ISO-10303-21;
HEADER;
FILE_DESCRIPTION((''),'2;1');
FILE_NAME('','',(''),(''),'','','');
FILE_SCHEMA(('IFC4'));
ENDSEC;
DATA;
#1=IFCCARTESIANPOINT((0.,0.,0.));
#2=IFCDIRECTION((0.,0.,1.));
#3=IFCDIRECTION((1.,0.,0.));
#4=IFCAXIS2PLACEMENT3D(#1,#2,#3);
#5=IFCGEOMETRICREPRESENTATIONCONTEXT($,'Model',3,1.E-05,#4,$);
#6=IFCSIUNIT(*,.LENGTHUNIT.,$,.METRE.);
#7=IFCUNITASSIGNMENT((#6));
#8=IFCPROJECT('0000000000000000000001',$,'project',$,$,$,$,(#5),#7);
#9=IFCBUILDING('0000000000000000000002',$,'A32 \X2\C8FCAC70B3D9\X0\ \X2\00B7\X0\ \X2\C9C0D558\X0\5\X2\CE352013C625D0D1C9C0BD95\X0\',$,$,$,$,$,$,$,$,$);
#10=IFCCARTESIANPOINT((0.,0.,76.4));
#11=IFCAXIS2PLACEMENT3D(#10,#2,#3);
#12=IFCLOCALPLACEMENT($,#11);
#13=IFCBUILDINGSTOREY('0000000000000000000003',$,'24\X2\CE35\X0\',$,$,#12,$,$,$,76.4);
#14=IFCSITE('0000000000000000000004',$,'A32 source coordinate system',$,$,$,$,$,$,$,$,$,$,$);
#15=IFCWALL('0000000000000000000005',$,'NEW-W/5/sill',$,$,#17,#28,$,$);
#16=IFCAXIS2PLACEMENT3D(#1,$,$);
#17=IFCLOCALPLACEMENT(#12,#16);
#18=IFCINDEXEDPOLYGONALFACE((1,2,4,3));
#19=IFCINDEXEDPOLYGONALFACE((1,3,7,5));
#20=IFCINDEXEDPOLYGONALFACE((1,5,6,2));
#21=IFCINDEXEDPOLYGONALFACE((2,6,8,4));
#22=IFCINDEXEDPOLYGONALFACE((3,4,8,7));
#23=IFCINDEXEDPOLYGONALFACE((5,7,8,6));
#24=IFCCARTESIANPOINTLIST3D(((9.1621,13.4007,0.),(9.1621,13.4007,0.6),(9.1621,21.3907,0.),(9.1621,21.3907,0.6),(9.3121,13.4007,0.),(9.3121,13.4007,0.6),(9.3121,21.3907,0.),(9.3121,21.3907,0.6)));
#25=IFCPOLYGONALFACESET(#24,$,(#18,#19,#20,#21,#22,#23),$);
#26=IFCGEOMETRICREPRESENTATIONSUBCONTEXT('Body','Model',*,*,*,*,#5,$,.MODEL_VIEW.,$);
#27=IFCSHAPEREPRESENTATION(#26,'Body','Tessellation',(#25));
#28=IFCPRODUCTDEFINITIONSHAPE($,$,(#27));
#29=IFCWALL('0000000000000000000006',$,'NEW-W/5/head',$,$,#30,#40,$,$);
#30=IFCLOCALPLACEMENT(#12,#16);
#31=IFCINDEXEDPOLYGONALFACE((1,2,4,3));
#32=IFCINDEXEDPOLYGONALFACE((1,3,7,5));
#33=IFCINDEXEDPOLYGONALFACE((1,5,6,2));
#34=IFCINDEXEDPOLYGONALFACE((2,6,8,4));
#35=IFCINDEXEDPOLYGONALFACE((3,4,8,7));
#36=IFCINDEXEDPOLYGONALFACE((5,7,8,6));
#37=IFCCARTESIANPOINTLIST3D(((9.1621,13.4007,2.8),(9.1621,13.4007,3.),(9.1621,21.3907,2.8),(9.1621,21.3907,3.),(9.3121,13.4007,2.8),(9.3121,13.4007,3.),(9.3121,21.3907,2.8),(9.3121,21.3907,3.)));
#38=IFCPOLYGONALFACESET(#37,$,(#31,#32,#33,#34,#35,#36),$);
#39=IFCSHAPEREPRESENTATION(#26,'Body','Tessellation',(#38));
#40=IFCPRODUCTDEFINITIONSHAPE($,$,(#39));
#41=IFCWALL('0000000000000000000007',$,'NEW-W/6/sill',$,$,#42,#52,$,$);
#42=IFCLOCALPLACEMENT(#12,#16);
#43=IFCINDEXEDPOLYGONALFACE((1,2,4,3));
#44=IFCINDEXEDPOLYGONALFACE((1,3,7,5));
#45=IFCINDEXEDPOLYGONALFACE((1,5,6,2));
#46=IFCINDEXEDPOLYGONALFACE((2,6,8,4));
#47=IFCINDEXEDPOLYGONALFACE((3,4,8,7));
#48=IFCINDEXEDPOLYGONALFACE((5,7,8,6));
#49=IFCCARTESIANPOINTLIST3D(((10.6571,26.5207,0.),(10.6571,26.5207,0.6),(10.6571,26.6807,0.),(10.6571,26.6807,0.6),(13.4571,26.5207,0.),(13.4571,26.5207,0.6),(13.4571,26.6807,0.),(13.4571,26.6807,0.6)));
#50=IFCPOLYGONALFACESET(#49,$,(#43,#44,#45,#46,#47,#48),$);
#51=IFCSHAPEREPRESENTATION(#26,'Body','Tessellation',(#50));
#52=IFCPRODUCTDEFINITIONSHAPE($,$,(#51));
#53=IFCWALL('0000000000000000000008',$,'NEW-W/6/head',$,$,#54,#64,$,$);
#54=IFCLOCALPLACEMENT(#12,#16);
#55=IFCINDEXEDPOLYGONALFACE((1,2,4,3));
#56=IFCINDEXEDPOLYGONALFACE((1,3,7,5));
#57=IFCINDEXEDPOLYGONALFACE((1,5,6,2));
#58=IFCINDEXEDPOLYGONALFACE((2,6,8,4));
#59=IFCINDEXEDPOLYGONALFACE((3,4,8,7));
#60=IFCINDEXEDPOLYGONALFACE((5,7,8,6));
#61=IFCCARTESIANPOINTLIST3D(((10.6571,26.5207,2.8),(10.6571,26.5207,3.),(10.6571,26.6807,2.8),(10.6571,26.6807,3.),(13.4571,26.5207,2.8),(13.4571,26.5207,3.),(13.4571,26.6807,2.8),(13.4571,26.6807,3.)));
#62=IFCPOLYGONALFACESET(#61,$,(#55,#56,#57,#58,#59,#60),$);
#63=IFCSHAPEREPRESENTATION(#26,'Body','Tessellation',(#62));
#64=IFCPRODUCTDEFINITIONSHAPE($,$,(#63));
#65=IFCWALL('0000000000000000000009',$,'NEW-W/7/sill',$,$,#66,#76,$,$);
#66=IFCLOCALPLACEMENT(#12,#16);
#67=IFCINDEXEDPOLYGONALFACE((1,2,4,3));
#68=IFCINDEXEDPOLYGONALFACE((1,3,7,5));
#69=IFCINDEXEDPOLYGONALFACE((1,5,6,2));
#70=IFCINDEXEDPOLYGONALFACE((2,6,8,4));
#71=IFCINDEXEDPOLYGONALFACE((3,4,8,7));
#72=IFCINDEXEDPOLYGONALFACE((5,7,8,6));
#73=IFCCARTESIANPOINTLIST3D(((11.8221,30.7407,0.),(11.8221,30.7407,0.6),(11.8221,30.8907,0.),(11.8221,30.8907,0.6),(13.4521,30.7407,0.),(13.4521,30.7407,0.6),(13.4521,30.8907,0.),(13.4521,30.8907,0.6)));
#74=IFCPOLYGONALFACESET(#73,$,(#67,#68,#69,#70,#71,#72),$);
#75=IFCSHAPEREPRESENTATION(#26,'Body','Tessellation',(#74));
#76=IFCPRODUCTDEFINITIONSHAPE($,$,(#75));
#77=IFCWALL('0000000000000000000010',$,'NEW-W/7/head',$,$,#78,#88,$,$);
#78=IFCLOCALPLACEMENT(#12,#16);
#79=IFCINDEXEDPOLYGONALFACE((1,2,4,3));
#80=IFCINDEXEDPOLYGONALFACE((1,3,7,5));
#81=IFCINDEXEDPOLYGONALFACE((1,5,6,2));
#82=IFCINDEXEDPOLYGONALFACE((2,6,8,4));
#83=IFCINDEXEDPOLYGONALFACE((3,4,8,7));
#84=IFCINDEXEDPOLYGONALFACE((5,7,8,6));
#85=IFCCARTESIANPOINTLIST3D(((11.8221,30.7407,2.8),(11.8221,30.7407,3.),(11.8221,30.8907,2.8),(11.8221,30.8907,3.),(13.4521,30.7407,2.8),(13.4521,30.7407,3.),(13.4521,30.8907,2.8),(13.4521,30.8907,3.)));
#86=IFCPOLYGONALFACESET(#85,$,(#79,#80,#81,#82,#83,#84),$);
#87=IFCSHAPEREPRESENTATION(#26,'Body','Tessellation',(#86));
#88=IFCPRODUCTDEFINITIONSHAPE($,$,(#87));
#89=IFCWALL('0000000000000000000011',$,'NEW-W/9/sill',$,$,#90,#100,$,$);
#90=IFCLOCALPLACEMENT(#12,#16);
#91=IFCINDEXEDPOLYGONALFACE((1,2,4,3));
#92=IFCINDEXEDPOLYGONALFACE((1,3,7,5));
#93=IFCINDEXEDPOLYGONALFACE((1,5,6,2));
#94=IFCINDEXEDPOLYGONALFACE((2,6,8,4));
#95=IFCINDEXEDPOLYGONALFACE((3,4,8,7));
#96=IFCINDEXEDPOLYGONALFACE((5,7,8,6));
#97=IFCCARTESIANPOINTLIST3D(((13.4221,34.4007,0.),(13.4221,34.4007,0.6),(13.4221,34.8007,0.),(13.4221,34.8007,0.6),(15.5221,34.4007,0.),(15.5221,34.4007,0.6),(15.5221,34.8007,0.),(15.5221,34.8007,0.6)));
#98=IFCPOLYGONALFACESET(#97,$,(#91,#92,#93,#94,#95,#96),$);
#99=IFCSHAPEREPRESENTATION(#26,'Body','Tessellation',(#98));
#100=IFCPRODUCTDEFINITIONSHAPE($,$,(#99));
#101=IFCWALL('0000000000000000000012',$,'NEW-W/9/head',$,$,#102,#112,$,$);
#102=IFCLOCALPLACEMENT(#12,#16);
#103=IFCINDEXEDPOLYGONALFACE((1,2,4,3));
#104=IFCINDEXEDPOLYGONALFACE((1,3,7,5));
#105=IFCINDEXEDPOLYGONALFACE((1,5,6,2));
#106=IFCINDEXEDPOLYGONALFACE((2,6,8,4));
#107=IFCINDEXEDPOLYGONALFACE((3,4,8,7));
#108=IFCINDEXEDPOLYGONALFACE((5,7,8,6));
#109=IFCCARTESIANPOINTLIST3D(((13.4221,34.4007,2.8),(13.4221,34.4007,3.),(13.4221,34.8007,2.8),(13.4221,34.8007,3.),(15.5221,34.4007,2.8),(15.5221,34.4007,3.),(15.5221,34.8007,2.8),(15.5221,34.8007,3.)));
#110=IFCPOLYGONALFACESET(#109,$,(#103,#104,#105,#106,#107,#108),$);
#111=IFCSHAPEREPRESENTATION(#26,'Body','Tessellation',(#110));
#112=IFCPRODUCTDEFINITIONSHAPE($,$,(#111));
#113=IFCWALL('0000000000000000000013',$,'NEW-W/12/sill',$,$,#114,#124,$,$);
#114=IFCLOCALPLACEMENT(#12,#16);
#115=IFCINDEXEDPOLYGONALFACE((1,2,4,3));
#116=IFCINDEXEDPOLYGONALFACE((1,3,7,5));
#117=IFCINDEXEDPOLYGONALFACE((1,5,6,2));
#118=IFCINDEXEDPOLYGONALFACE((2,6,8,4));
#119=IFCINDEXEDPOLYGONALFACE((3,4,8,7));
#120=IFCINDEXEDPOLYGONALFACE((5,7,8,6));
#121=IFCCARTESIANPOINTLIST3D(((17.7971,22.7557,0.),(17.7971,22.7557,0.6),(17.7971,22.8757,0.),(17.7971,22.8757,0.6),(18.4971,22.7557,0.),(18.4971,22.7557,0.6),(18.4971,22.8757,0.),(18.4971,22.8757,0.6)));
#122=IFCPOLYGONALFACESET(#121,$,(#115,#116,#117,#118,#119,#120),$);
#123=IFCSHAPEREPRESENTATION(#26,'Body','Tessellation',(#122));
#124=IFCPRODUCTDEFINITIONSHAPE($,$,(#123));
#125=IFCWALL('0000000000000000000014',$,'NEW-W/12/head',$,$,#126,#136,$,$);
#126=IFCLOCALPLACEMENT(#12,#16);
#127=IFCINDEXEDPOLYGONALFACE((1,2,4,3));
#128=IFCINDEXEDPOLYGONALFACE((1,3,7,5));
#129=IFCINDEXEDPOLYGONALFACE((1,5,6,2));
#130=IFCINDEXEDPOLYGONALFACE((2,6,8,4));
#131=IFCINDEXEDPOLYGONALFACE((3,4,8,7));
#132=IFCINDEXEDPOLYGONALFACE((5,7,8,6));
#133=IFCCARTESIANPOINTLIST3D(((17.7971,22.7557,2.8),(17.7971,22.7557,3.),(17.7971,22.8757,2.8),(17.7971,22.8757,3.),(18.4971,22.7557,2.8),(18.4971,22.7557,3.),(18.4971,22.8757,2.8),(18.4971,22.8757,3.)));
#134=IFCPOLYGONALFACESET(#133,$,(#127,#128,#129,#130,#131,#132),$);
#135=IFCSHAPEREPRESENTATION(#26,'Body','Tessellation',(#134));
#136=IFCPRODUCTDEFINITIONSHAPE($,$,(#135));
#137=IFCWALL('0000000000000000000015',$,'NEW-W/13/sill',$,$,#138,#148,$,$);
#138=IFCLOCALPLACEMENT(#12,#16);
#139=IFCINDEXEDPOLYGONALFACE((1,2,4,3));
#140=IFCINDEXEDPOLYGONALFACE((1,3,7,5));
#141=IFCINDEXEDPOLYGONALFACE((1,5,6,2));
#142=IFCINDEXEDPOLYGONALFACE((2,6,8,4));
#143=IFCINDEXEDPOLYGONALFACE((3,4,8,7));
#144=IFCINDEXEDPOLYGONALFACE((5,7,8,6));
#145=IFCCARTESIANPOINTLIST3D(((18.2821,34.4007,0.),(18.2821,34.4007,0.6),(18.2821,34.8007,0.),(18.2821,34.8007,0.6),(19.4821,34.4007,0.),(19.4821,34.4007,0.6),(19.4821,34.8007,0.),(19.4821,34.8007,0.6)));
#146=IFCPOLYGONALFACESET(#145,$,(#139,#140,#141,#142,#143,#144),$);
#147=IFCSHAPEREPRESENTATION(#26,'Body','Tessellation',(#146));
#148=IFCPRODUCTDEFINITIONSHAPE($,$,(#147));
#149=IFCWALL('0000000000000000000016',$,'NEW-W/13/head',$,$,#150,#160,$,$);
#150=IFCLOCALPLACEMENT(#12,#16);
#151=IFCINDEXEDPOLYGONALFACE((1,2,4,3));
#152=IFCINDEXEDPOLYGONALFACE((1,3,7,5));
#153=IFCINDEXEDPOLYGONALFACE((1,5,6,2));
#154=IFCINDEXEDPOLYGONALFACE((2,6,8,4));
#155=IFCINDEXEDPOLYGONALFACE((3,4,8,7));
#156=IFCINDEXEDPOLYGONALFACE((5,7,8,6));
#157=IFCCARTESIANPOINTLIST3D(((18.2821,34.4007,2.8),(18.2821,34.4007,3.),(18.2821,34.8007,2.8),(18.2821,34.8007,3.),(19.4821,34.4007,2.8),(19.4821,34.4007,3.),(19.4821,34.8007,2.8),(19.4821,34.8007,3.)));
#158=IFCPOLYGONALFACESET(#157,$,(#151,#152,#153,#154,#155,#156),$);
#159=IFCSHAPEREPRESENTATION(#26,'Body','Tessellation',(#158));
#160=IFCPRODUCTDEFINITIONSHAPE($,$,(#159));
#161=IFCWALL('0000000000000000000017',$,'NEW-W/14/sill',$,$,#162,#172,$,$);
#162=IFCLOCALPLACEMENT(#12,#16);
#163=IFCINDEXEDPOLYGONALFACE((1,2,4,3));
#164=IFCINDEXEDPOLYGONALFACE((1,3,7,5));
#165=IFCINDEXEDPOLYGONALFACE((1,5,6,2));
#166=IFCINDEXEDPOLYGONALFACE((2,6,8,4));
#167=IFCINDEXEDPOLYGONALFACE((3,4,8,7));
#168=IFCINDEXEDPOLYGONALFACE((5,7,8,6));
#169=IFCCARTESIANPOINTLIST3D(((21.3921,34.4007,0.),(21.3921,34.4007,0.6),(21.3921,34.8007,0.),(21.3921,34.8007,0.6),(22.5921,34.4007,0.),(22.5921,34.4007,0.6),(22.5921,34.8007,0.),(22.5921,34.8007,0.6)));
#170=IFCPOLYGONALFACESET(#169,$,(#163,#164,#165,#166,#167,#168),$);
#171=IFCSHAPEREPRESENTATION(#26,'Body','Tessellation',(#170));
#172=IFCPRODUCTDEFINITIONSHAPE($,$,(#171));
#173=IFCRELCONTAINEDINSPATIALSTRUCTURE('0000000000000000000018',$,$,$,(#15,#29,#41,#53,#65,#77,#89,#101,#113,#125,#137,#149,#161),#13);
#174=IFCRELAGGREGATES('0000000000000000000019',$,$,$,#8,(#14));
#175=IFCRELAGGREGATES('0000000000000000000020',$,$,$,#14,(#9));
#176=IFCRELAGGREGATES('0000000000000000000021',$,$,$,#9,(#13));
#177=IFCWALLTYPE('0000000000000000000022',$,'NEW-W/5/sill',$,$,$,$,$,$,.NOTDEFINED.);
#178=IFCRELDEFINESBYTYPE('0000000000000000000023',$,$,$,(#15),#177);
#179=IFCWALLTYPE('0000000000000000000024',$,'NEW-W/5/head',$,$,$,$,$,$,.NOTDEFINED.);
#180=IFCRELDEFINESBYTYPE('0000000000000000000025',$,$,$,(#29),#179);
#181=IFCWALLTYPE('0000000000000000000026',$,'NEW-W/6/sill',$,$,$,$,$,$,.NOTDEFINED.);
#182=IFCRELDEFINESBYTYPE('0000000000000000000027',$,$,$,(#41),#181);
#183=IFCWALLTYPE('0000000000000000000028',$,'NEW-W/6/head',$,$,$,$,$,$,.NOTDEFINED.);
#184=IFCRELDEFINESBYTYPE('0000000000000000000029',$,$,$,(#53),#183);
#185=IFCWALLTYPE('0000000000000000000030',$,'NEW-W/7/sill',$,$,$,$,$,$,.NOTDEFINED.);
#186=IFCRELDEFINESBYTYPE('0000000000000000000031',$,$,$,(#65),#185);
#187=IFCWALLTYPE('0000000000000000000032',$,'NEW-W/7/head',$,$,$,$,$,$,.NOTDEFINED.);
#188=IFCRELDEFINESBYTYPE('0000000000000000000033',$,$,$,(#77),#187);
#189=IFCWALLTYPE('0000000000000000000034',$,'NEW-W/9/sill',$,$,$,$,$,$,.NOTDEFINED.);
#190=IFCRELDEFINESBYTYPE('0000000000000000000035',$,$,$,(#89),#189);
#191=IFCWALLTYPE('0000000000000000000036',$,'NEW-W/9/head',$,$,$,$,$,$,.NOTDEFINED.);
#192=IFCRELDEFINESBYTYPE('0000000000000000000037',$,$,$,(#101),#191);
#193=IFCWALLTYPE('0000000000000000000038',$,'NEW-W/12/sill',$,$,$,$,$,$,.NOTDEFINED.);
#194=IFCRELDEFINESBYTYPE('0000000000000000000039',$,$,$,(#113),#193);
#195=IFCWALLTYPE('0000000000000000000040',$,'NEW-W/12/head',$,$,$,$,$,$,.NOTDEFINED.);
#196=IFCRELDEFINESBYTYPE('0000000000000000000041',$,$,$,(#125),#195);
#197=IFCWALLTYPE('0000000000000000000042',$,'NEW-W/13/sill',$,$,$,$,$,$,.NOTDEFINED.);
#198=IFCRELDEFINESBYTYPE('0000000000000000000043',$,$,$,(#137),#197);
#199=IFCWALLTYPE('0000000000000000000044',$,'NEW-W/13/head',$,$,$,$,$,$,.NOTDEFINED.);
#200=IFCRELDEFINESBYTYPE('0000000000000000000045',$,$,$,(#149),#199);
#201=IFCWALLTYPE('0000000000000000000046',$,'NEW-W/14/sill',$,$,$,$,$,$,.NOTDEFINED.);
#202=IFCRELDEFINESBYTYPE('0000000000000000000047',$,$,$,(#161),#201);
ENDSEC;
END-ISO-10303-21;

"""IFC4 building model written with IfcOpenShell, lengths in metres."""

from ifc_helpers import new_model, si_unit, frame, origin, origin_with_axes, place, context, subcontext, project, spatial, polyline, outline, extrude, source, transform, mapped, type_object, type_shapes, element, save


model = new_model("IFC4")

# Units and contexts
model_context = context("Model", 3, precision=1e-05, world=origin_with_axes())
body_context = subcontext(model_context, "Body", "Model", "MODEL_VIEW")
ifc_project = project(units=[si_unit("LENGTHUNIT", "METRE")], contexts=[model_context])

# Site, building, storey
site = spatial("IfcSite", under=ifc_project, Name="A32 source coordinate system")
building = spatial("IfcBuilding", under=site, Name="A32 주거동 · 지하5층–옥탑지붕")
storey_placement = place(None, frame((0.0, 0.0, 76.4), z_axis=(0.0, 0.0, 1.0), x_axis=(1.0, 0.0, 0.0)))
storey = spatial("IfcBuildingStorey", under=building, at=storey_placement, Name="24층", Elevation=76.4)

# Walls
wall_type_1 = type_object("IfcWallType", Name="NEW-W/5/sill", PredefinedType="NOTDEFINED")
shared_shape_1 = source(origin(), body_context, "Body", "SweptSolid", [
    extrude(outline(polyline([(9.1621, 13.4007), (9.1621, 21.3907), (9.3121, 21.3907), (9.3121, 13.4007), (9.1621, 13.4007)])), origin(), (0.0, 0.0, 1.0), 0.6),
])
type_shapes(wall_type_1, [shared_shape_1])
wall_1_placement = place(storey_placement, origin_with_axes())
element("IfcWall", 1, at=wall_1_placement, inside=storey, type_object=wall_type_1, Name="NEW-W/5/sill", context=body_context, shape_type="MappedRepresentation", body=[
    mapped(shared_shape_1, transform((0.0, 0.0, 0.0), scale=1.0)),
])
wall_type_2 = type_object("IfcWallType", Name="NEW-W/5/head", PredefinedType="NOTDEFINED")
shared_shape_2 = source(origin(), body_context, "Body", "SweptSolid", [
    extrude(outline(polyline([(9.1621, 13.4007), (9.1621, 21.3907), (9.3121, 21.3907), (9.3121, 13.4007), (9.1621, 13.4007)])), frame((0.0, 0.0, 2.8)), (0.0, 0.0, 1.0), 0.2),
])
type_shapes(wall_type_2, [shared_shape_2])
wall_2_placement = place(storey_placement, origin_with_axes())
element("IfcWall", 2, at=wall_2_placement, inside=storey, type_object=wall_type_2, Name="NEW-W/5/head", context=body_context, shape_type="MappedRepresentation", body=[
    mapped(shared_shape_2, transform((0.0, 0.0, 0.0), scale=1.0)),
])
wall_type_3 = type_object("IfcWallType", Name="NEW-W/6/sill", PredefinedType="NOTDEFINED")
shared_shape_3 = source(origin(), body_context, "Body", "SweptSolid", [
    extrude(outline(polyline([(10.6571, 26.5207), (10.6571, 26.6807), (13.4571, 26.6807), (13.4571, 26.5207), (10.6571, 26.5207)])), origin(), (0.0, 0.0, 1.0), 0.6),
])
type_shapes(wall_type_3, [shared_shape_3])
wall_3_placement = place(storey_placement, origin_with_axes())
element("IfcWall", 3, at=wall_3_placement, inside=storey, type_object=wall_type_3, Name="NEW-W/6/sill", context=body_context, shape_type="MappedRepresentation", body=[
    mapped(shared_shape_3, transform((0.0, 0.0, 0.0), scale=1.0)),
])
wall_type_4 = type_object("IfcWallType", Name="NEW-W/6/head", PredefinedType="NOTDEFINED")
shared_shape_4 = source(origin(), body_context, "Body", "SweptSolid", [
    extrude(outline(polyline([(10.6571, 26.5207), (10.6571, 26.6807), (13.4571, 26.6807), (13.4571, 26.5207), (10.6571, 26.5207)])), frame((0.0, 0.0, 2.8)), (0.0, 0.0, 1.0), 0.2),
])
type_shapes(wall_type_4, [shared_shape_4])
wall_4_placement = place(storey_placement, origin_with_axes())
element("IfcWall", 4, at=wall_4_placement, inside=storey, type_object=wall_type_4, Name="NEW-W/6/head", context=body_context, shape_type="MappedRepresentation", body=[
    mapped(shared_shape_4, transform((0.0, 0.0, 0.0), scale=1.0)),
])
wall_type_5 = type_object("IfcWallType", Name="NEW-W/7/sill", PredefinedType="NOTDEFINED")
shared_shape_5 = source(origin(), body_context, "Body", "SweptSolid", [
    extrude(outline(polyline([(11.8221, 30.7407), (11.8221, 30.8907), (13.4521, 30.8907), (13.4521, 30.7407), (11.8221, 30.7407)])), origin(), (0.0, 0.0, 1.0), 0.6),
])
type_shapes(wall_type_5, [shared_shape_5])
wall_5_placement = place(storey_placement, origin_with_axes())
element("IfcWall", 5, at=wall_5_placement, inside=storey, type_object=wall_type_5, Name="NEW-W/7/sill", context=body_context, shape_type="MappedRepresentation", body=[
    mapped(shared_shape_5, transform((0.0, 0.0, 0.0), scale=1.0)),
])
wall_type_6 = type_object("IfcWallType", Name="NEW-W/7/head", PredefinedType="NOTDEFINED")
shared_shape_6 = source(origin(), body_context, "Body", "SweptSolid", [
    extrude(outline(polyline([(11.8221, 30.7407), (11.8221, 30.8907), (13.4521, 30.8907), (13.4521, 30.7407), (11.8221, 30.7407)])), frame((0.0, 0.0, 2.8)), (0.0, 0.0, 1.0), 0.2),
])
type_shapes(wall_type_6, [shared_shape_6])
wall_6_placement = place(storey_placement, origin_with_axes())
element("IfcWall", 6, at=wall_6_placement, inside=storey, type_object=wall_type_6, Name="NEW-W/7/head", context=body_context, shape_type="MappedRepresentation", body=[
    mapped(shared_shape_6, transform((0.0, 0.0, 0.0), scale=1.0)),
])
wall_type_7 = type_object("IfcWallType", Name="NEW-W/9/sill", PredefinedType="NOTDEFINED")
shared_shape_7 = source(origin(), body_context, "Body", "SweptSolid", [
    extrude(outline(polyline([(13.4221, 34.4007), (13.4221, 34.8007), (15.5221, 34.8007), (15.5221, 34.4007), (13.4221, 34.4007)])), origin(), (0.0, 0.0, 1.0), 0.6),
])
type_shapes(wall_type_7, [shared_shape_7])
wall_7_placement = place(storey_placement, origin_with_axes())
element("IfcWall", 7, at=wall_7_placement, inside=storey, type_object=wall_type_7, Name="NEW-W/9/sill", context=body_context, shape_type="MappedRepresentation", body=[
    mapped(shared_shape_7, transform((0.0, 0.0, 0.0), scale=1.0)),
])
wall_type_8 = type_object("IfcWallType", Name="NEW-W/9/head", PredefinedType="NOTDEFINED")
shared_shape_8 = source(origin(), body_context, "Body", "SweptSolid", [
    extrude(outline(polyline([(13.4221, 34.4007), (13.4221, 34.8007), (15.5221, 34.8007), (15.5221, 34.4007), (13.4221, 34.4007)])), frame((0.0, 0.0, 2.8)), (0.0, 0.0, 1.0), 0.2),
])
type_shapes(wall_type_8, [shared_shape_8])
wall_8_placement = place(storey_placement, origin_with_axes())
element("IfcWall", 8, at=wall_8_placement, inside=storey, type_object=wall_type_8, Name="NEW-W/9/head", context=body_context, shape_type="MappedRepresentation", body=[
    mapped(shared_shape_8, transform((0.0, 0.0, 0.0), scale=1.0)),
])
wall_type_9 = type_object("IfcWallType", Name="NEW-W/12/sill", PredefinedType="NOTDEFINED")
shared_shape_9 = source(origin(), body_context, "Body", "SweptSolid", [
    extrude(outline(polyline([(17.7971, 22.7557), (17.7971, 22.8757), (18.4971, 22.8757), (18.4971, 22.7557), (17.7971, 22.7557)])), origin(), (0.0, 0.0, 1.0), 0.6),
])
type_shapes(wall_type_9, [shared_shape_9])
wall_9_placement = place(storey_placement, origin_with_axes())
element("IfcWall", 9, at=wall_9_placement, inside=storey, type_object=wall_type_9, Name="NEW-W/12/sill", context=body_context, shape_type="MappedRepresentation", body=[
    mapped(shared_shape_9, transform((0.0, 0.0, 0.0), scale=1.0)),
])
wall_type_10 = type_object("IfcWallType", Name="NEW-W/12/head", PredefinedType="NOTDEFINED")
shared_shape_10 = source(origin(), body_context, "Body", "SweptSolid", [
    extrude(outline(polyline([(17.7971, 22.7557), (17.7971, 22.8757), (18.4971, 22.8757), (18.4971, 22.7557), (17.7971, 22.7557)])), frame((0.0, 0.0, 2.8)), (0.0, 0.0, 1.0), 0.2),
])
type_shapes(wall_type_10, [shared_shape_10])
wall_10_placement = place(storey_placement, origin_with_axes())
element("IfcWall", 10, at=wall_10_placement, inside=storey, type_object=wall_type_10, Name="NEW-W/12/head", context=body_context, shape_type="MappedRepresentation", body=[
    mapped(shared_shape_10, transform((0.0, 0.0, 0.0), scale=1.0)),
])
wall_type_11 = type_object("IfcWallType", Name="NEW-W/13/sill", PredefinedType="NOTDEFINED")
shared_shape_11 = source(origin(), body_context, "Body", "SweptSolid", [
    extrude(outline(polyline([(18.2821, 34.4007), (18.2821, 34.8007), (19.4821, 34.8007), (19.4821, 34.4007), (18.2821, 34.4007)])), origin(), (0.0, 0.0, 1.0), 0.6),
])
type_shapes(wall_type_11, [shared_shape_11])
wall_11_placement = place(storey_placement, origin_with_axes())
element("IfcWall", 11, at=wall_11_placement, inside=storey, type_object=wall_type_11, Name="NEW-W/13/sill", context=body_context, shape_type="MappedRepresentation", body=[
    mapped(shared_shape_11, transform((0.0, 0.0, 0.0), scale=1.0)),
])
wall_type_12 = type_object("IfcWallType", Name="NEW-W/13/head", PredefinedType="NOTDEFINED")
shared_shape_12 = source(origin(), body_context, "Body", "SweptSolid", [
    extrude(outline(polyline([(18.2821, 34.4007), (18.2821, 34.8007), (19.4821, 34.8007), (19.4821, 34.4007), (18.2821, 34.4007)])), frame((0.0, 0.0, 2.8)), (0.0, 0.0, 1.0), 0.2),
])
type_shapes(wall_type_12, [shared_shape_12])
wall_12_placement = place(storey_placement, origin_with_axes())
element("IfcWall", 12, at=wall_12_placement, inside=storey, type_object=wall_type_12, Name="NEW-W/13/head", context=body_context, shape_type="MappedRepresentation", body=[
    mapped(shared_shape_12, transform((0.0, 0.0, 0.0), scale=1.0)),
])
wall_type_13 = type_object("IfcWallType", Name="NEW-W/14/sill", PredefinedType="NOTDEFINED")
shared_shape_13 = source(origin(), body_context, "Body", "SweptSolid", [
    extrude(outline(polyline([(21.3921, 34.4007), (21.3921, 34.8007), (22.5921, 34.8007), (22.5921, 34.4007), (21.3921, 34.4007)])), origin(), (0.0, 0.0, 1.0), 0.6),
])
type_shapes(wall_type_13, [shared_shape_13])
wall_13_placement = place(storey_placement, origin_with_axes())
element("IfcWall", 13, at=wall_13_placement, inside=storey, type_object=wall_type_13, Name="NEW-W/14/sill", context=body_context, shape_type="MappedRepresentation", body=[
    mapped(shared_shape_13, transform((0.0, 0.0, 0.0), scale=1.0)),
])

save(model, "model.ifc")
